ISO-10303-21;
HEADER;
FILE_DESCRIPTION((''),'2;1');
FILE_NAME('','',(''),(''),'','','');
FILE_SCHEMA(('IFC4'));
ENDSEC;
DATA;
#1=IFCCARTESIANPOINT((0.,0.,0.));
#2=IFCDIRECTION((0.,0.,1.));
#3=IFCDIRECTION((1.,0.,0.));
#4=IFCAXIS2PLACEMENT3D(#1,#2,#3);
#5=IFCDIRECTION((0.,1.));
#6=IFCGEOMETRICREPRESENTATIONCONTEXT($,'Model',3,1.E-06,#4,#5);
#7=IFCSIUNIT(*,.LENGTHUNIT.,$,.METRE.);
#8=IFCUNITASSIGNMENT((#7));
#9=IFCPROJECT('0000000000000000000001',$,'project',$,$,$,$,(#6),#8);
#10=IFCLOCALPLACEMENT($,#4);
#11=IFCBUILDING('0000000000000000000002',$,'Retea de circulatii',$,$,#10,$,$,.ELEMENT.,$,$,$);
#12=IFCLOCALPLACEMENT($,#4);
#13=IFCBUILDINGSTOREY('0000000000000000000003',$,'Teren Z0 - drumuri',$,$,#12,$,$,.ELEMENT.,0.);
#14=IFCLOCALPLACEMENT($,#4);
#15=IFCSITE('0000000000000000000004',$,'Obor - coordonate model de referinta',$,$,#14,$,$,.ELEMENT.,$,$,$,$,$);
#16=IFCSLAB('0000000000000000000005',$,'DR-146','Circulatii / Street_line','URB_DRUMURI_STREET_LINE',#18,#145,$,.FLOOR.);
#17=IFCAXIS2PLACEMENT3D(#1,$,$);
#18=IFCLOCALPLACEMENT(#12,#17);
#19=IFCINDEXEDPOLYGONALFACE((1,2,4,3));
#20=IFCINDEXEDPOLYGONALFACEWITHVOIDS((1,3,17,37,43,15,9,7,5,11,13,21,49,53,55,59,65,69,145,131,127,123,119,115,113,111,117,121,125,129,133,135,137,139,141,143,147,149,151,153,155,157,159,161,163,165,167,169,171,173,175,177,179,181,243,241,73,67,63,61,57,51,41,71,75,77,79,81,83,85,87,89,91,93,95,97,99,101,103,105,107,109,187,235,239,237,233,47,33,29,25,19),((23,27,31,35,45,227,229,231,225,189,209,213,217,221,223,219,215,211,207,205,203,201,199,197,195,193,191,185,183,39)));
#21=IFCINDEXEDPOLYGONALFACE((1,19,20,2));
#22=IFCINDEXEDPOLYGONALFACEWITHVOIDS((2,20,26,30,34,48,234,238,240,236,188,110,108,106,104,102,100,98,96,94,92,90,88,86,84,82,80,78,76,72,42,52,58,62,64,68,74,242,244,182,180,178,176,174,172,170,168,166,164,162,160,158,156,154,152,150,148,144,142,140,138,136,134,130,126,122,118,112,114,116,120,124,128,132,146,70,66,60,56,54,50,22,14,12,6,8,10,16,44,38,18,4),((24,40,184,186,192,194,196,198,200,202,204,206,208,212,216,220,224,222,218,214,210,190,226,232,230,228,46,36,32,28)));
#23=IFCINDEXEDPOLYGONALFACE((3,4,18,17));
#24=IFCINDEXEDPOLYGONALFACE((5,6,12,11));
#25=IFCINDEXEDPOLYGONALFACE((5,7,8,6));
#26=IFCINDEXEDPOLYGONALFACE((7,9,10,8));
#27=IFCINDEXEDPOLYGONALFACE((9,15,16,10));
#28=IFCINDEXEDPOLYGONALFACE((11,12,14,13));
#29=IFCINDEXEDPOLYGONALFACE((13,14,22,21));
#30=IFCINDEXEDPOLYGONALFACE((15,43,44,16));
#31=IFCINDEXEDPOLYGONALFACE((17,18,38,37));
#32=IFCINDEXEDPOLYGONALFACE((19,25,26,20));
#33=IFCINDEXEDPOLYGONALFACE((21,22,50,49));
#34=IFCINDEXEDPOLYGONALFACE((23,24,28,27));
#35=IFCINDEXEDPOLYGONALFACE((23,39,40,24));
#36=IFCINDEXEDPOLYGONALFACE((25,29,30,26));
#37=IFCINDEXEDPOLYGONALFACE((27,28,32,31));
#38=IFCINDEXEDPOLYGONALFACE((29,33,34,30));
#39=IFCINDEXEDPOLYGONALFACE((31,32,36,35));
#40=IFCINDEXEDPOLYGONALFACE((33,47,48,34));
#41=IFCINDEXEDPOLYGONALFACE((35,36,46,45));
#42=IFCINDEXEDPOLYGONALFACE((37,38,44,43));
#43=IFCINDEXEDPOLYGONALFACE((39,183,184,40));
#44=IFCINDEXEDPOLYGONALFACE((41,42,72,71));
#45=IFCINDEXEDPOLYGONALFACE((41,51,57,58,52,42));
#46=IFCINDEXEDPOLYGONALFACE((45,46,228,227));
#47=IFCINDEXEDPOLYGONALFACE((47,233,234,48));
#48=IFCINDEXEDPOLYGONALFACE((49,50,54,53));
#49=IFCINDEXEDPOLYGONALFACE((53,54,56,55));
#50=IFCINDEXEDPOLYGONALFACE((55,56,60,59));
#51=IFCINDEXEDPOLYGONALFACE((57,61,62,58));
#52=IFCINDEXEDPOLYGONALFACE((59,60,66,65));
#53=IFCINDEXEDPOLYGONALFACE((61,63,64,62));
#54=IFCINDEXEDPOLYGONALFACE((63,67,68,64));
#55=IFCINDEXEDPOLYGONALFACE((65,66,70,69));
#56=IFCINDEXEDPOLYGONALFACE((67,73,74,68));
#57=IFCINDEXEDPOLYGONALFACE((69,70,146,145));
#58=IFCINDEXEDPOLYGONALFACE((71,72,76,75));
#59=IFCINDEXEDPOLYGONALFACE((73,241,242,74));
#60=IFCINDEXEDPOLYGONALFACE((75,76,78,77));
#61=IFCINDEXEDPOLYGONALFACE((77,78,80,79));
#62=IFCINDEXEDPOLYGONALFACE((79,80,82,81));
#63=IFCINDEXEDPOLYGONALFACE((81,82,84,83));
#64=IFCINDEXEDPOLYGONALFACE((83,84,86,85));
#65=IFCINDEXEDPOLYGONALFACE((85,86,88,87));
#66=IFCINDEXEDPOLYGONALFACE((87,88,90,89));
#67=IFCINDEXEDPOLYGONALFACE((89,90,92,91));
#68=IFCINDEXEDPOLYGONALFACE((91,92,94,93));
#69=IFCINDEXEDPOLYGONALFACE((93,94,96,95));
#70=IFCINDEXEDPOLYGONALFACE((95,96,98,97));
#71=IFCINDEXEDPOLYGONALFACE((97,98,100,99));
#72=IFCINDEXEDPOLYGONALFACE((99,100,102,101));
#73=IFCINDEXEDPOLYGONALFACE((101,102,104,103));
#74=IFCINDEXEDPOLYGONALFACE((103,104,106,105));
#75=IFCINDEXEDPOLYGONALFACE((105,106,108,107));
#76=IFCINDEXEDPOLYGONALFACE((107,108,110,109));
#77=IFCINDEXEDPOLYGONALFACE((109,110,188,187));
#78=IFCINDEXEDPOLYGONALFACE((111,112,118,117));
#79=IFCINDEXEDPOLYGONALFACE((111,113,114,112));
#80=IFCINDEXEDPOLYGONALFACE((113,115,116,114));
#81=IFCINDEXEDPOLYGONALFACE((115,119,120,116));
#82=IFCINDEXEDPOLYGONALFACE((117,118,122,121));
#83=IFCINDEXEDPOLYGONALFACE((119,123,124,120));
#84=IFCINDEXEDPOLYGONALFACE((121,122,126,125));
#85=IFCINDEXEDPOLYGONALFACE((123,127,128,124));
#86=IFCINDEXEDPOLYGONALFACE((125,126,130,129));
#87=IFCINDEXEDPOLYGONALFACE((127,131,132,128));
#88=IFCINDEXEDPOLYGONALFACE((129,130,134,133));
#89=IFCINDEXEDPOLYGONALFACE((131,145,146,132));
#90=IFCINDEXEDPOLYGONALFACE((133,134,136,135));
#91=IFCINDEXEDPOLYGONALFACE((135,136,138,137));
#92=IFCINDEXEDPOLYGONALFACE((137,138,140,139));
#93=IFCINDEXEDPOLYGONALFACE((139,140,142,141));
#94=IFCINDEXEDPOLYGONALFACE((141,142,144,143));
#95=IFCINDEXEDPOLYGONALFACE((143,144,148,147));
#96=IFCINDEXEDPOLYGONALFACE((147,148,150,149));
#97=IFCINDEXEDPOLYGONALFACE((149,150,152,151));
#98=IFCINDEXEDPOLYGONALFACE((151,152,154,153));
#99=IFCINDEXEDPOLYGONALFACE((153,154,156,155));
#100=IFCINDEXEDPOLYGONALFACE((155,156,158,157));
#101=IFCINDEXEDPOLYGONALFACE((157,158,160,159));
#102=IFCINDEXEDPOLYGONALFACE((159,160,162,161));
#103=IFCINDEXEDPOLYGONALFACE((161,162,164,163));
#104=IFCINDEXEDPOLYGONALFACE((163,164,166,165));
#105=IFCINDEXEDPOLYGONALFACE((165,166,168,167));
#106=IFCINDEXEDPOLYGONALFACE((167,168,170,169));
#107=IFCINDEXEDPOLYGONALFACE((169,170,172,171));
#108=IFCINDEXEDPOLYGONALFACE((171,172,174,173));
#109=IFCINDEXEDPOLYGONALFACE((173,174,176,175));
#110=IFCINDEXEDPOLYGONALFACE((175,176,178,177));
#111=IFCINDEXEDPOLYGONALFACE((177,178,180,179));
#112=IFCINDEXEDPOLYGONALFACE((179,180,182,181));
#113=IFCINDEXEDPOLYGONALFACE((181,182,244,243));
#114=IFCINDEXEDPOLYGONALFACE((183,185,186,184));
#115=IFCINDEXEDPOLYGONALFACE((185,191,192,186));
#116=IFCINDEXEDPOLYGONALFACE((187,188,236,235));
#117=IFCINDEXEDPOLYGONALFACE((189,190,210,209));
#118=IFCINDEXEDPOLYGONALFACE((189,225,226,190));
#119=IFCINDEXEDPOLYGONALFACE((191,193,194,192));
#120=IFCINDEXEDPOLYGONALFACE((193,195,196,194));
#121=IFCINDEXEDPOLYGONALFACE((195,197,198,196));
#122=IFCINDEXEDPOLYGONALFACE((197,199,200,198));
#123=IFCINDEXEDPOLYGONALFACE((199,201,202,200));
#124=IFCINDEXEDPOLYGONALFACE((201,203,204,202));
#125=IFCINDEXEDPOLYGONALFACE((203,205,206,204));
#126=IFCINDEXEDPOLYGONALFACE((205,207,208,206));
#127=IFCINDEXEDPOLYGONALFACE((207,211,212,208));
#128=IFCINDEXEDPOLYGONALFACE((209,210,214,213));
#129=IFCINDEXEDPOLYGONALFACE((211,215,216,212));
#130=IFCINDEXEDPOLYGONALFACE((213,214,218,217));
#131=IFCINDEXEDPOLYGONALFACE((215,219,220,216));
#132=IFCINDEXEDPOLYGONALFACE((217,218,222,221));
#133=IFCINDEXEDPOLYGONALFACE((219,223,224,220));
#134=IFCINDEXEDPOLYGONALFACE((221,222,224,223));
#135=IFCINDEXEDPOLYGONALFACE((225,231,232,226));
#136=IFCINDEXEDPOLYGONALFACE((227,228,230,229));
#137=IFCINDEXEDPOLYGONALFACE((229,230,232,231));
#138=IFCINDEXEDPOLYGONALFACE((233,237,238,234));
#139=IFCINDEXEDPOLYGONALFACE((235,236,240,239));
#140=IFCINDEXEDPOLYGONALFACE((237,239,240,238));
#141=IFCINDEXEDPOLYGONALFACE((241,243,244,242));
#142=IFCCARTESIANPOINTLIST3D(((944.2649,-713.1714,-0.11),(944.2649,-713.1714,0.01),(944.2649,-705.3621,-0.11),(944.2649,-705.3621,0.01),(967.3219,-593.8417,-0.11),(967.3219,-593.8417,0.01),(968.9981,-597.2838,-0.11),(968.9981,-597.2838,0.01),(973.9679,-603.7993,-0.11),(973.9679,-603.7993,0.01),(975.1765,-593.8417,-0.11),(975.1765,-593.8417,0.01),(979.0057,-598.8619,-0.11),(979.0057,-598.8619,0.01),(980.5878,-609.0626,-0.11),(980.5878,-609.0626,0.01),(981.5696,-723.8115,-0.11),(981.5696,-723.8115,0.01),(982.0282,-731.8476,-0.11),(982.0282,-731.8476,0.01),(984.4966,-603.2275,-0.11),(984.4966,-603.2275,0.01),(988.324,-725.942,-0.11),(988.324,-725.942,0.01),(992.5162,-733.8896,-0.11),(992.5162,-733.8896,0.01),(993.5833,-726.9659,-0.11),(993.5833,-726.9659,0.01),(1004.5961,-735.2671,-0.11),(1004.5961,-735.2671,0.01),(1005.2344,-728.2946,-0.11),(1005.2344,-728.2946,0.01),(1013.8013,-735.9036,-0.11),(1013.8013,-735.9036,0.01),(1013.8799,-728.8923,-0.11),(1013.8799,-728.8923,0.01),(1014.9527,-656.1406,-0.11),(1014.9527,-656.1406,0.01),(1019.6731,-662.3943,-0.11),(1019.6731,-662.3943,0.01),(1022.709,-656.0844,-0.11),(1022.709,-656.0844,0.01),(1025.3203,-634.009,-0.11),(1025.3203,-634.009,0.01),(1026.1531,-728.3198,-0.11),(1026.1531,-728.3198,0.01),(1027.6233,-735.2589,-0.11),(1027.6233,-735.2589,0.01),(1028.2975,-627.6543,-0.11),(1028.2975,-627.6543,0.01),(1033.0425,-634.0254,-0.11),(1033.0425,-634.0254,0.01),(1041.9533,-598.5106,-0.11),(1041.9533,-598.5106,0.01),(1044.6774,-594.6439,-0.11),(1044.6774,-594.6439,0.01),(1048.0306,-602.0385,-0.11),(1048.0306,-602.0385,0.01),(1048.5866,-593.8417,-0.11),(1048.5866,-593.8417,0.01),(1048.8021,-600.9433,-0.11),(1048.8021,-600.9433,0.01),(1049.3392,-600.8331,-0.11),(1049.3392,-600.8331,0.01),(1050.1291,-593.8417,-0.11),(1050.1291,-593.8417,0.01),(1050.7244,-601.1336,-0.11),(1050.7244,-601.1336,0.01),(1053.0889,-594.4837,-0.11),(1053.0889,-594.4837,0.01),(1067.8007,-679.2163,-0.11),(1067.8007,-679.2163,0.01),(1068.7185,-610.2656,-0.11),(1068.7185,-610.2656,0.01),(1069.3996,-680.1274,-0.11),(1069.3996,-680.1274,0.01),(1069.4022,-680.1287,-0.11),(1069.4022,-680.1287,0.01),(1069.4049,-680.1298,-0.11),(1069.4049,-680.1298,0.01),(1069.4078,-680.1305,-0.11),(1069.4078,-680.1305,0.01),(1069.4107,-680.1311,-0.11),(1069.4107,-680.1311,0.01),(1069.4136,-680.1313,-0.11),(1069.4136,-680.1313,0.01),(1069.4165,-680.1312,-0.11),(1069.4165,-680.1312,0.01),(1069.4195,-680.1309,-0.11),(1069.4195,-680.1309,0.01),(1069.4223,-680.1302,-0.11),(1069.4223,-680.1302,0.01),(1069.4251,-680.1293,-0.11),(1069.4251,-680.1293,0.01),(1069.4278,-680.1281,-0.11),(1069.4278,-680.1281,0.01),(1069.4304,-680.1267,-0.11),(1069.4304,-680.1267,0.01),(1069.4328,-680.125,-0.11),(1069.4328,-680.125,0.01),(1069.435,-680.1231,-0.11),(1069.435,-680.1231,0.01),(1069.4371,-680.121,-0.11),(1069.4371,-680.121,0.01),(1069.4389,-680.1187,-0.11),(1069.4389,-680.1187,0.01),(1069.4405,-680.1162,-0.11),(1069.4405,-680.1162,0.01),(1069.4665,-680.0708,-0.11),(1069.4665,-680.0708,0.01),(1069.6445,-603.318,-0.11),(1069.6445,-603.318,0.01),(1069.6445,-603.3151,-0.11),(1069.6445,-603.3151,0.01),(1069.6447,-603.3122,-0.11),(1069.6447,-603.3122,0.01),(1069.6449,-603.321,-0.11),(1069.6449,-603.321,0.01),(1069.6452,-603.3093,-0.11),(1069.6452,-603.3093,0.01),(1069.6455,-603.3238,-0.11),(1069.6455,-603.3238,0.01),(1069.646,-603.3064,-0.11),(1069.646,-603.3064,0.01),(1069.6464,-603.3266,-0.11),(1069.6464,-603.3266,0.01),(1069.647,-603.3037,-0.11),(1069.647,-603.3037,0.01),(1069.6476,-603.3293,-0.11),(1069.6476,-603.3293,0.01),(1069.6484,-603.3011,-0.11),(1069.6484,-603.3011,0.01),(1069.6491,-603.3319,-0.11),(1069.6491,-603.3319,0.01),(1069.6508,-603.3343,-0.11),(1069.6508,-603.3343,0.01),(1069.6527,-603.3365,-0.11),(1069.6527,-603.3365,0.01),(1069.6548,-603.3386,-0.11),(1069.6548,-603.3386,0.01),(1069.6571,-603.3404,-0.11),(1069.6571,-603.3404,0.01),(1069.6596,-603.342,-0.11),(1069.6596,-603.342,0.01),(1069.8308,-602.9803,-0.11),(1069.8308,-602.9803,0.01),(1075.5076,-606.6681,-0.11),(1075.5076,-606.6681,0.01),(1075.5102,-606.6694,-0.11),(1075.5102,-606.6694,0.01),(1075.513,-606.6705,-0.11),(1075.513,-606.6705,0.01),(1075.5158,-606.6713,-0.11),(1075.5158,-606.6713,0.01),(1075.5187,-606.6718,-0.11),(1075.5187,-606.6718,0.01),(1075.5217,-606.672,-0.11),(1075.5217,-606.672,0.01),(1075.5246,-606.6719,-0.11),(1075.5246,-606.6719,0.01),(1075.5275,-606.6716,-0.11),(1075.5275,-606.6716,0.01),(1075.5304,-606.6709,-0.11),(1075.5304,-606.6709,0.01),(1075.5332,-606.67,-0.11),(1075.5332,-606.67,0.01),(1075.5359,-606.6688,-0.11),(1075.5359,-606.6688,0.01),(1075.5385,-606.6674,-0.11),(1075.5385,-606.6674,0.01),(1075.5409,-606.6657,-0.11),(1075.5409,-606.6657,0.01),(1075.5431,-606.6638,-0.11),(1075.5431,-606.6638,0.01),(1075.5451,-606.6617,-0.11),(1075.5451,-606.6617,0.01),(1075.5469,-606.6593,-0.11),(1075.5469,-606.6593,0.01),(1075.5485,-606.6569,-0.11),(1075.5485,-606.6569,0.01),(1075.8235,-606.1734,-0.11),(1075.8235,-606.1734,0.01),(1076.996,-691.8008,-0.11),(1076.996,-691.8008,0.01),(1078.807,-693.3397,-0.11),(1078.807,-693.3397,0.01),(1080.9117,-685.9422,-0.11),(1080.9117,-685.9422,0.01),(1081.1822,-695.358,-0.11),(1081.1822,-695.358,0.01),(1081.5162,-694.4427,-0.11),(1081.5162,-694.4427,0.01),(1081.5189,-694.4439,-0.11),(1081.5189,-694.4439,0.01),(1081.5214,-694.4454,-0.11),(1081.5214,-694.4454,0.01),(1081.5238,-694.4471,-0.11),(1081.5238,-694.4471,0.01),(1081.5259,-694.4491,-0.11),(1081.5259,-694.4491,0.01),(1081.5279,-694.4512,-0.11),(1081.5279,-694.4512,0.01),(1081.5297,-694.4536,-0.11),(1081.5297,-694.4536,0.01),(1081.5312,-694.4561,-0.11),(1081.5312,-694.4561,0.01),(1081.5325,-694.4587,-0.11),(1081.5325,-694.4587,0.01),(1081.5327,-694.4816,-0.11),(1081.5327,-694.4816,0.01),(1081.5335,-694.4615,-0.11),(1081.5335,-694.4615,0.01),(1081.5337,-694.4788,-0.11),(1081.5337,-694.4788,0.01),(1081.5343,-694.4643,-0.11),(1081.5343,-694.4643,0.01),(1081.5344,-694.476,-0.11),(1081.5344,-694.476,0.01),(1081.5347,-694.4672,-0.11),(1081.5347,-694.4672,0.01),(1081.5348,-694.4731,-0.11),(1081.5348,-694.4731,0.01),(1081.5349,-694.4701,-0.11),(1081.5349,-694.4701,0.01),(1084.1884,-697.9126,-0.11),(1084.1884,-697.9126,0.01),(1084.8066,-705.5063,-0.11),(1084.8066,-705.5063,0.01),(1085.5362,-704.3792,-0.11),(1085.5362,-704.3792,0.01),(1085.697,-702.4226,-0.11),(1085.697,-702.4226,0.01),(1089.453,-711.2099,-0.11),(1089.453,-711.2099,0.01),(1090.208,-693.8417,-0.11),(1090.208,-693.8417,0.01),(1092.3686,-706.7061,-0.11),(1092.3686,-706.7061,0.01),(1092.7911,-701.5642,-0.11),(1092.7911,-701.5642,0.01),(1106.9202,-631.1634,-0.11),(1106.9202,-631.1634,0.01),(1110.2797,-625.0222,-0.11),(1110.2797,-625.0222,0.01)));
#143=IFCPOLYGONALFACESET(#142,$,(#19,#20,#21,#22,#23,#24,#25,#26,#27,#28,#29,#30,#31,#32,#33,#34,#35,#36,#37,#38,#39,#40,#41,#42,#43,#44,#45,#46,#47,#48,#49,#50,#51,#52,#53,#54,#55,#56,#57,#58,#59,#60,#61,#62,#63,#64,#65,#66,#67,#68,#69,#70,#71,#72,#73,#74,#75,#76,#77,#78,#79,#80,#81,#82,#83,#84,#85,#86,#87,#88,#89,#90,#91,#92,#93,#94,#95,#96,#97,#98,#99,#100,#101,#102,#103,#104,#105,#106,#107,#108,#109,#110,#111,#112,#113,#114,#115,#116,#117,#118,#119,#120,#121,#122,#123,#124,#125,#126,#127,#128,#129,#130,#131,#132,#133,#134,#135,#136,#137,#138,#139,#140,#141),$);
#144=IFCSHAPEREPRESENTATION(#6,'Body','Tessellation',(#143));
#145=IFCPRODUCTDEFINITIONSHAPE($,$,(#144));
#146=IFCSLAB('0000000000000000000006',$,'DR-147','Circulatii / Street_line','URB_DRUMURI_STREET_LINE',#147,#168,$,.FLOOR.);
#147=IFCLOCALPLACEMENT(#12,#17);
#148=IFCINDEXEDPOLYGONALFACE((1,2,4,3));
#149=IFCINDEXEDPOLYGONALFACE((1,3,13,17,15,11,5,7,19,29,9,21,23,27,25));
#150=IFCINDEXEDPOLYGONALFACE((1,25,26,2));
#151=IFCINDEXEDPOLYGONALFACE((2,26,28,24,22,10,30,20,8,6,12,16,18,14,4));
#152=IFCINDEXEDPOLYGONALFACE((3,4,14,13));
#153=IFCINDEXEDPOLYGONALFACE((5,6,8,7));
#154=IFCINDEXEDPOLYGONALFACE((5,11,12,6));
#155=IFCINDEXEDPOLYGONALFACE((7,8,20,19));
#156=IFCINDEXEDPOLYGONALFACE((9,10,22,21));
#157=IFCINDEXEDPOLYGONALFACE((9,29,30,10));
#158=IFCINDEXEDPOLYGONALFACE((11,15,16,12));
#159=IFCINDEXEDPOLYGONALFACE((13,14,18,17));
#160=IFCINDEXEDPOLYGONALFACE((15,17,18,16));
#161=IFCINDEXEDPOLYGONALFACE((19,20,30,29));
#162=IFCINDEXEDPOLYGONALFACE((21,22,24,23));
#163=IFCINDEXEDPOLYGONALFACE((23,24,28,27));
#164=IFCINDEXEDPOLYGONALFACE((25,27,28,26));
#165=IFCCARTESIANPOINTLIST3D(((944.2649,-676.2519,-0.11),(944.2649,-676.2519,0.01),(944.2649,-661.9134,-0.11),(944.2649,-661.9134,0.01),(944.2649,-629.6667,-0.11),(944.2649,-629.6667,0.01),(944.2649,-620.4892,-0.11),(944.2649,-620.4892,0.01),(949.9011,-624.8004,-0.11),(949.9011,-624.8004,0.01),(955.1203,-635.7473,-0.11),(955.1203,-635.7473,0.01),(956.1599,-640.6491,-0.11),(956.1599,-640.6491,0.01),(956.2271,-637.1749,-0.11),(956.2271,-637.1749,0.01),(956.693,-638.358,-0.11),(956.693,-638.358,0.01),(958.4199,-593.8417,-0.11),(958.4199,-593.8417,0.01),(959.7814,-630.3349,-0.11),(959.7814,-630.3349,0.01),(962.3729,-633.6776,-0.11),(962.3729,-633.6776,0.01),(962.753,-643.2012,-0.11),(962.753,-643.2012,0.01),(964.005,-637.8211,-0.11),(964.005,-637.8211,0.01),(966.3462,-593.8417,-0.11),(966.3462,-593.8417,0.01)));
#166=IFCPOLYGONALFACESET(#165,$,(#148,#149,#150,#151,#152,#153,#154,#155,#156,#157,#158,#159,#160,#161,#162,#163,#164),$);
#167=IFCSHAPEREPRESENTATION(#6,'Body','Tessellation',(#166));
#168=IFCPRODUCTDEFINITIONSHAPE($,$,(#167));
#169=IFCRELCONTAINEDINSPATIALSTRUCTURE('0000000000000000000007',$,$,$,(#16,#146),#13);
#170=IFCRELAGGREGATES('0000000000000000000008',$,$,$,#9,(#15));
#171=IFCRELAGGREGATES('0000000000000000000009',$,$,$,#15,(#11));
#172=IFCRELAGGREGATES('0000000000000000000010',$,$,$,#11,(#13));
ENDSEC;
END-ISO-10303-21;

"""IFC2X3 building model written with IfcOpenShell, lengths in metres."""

from ifc_helpers import new_model, si_unit, direction, frame, origin_with_axes, place, context, project, spatial, polyline, outline, extrude, element, save


model = new_model("IFC2X3")

# Units and contexts
model_context = context("Model", 3, precision=1e-06, world=origin_with_axes(), true_north=direction((0.0, 1.0)))
ifc_project = project(units=[si_unit("LENGTHUNIT", "METRE")], contexts=[model_context])

# Site, building, storey
site_placement = place(None, origin_with_axes())
site = spatial("IfcSite", under=ifc_project, at=site_placement, Name="Obor - coordonate model de referinta", CompositionType="ELEMENT")
building_placement = place(None, origin_with_axes())
building = spatial("IfcBuilding", under=site, at=building_placement, Name="Retea de circulatii", CompositionType="ELEMENT")
storey_placement = place(None, origin_with_axes())
storey = spatial("IfcBuildingStorey", under=building, at=storey_placement, Name="Teren Z0 - drumuri", CompositionType="ELEMENT", Elevation=0.0)

# Slabs
slab_1_placement = place(None, origin_with_axes())
element("IfcSlab", 1, at=slab_1_placement, inside=storey, Name="DR-146", Description="Circulatii / Street_line", ObjectType="URB_DRUMURI_STREET_LINE", PredefinedType="FLOOR", context=model_context, shape_type="SweptSolid", body=[
    extrude(outline(polyline([(1041.9533, -598.5106), (1028.2975, -627.6543), (984.4966, -603.2275), (979.0057, -598.8619), (975.1765, -593.8417), (967.3219, -593.8417), (968.9981, -597.2838), (973.9679, -603.7993), (980.5878, -609.0626), (1025.3203, -634.009), (1014.9527, -656.1406), (981.5696, -723.8115), (944.2649, -705.3621), (944.2649, -713.1714), (982.0282, -731.8476), (992.5162, -733.8896), (1004.5961, -735.2671), (1013.8013, -735.9036), (1027.6233, -735.2589), (1089.453, -711.2099), (1092.3686, -706.7061), (1092.7911, -701.5642), (1090.208, -693.8417), (1080.9117, -685.9422), (1069.4665, -680.0708), (1069.4405, -680.1162), (1069.4389, -680.1187), (1069.4371, -680.121), (1069.435, -680.1231), (1069.4328, -680.125), (1069.4304, -680.1267), (1069.4278, -680.1281), (1069.4251, -680.1293), (1069.4223, -680.1302), (1069.4195, -680.1309), (1069.4165, -680.1312), (1069.4136, -680.1313), (1069.4107, -680.1311), (1069.4078, -680.1305), (1069.4049, -680.1298), (1069.4022, -680.1287), (1069.3996, -680.1274), (1067.8007, -679.2163), (1022.709, -656.0844), (1033.0425, -634.0254), (1048.0306, -602.0385), (1048.8021, -600.9433), (1049.3392, -600.8331), (1050.7244, -601.1336), (1068.7185, -610.2656), (1106.9202, -631.1634), (1110.2797, -625.0222), (1075.8235, -606.1734), (1075.5485, -606.6569), (1075.5469, -606.6593), (1075.5451, -606.6617), (1075.5431, -606.6638), (1075.5409, -606.6657), (1075.5385, -606.6674), (1075.5359, -606.6688), (1075.5332, -606.67), (1075.5304, -606.6709), (1075.5275, -606.6716), (1075.5246, -606.6719), (1075.5217, -606.672), (1075.5187, -606.6718), (1075.5158, -606.6713), (1075.513, -606.6705), (1075.5102, -606.6694), (1075.5076, -606.6681), (1069.6596, -603.342), (1069.6571, -603.3404), (1069.6548, -603.3386), (1069.6527, -603.3365), (1069.6508, -603.3343), (1069.6491, -603.3319), (1069.6476, -603.3293), (1069.6464, -603.3266), (1069.6455, -603.3238), (1069.6449, -603.321), (1069.6445, -603.318), (1069.6445, -603.3151), (1069.6447, -603.3122), (1069.6452, -603.3093), (1069.646, -603.3064), (1069.647, -603.3037), (1069.6484, -603.3011), (1069.8308, -602.9803), (1053.0889, -594.4837), (1050.1291, -593.8417), (1048.5866, -593.8417), (1044.6774, -594.6439), (1041.9533, -598.5106)]), holes=[polyline([(1013.8799, -728.8923), (1005.2344, -728.2946), (993.5833, -726.9659), (988.324, -725.942), (1019.6731, -662.3943), (1076.996, -691.8008), (1078.807, -693.3397), (1081.5162, -694.4427), (1081.5189, -694.4439), (1081.5214, -694.4454), (1081.5238, -694.4471), (1081.5259, -694.4491), (1081.5279, -694.4512), (1081.5297, -694.4536), (1081.5312, -694.4561), (1081.5325, -694.4587), (1081.5335, -694.4615), (1081.5343, -694.4643), (1081.5347, -694.4672), (1081.5349, -694.4701), (1081.5348, -694.4731), (1081.5344, -694.476), (1081.5337, -694.4788), (1081.5327, -694.4816), (1081.1822, -695.358), (1084.1884, -697.9126), (1085.697, -702.4226), (1085.5362, -704.3792), (1084.8066, -705.5063), (1026.1531, -728.3198), (1013.8799, -728.8923)])]), frame((0.0, 0.0, -0.11), z_axis=(0.0, 0.0, 1.0), x_axis=(1.0, 0.0, 0.0)), (0.0, 0.0, 1.0), 0.12),
])
slab_2_placement = place(None, origin_with_axes())
element("IfcSlab", 2, at=slab_2_placement, inside=storey, Name="DR-147", Description="Circulatii / Street_line", ObjectType="URB_DRUMURI_STREET_LINE", PredefinedType="FLOOR", context=model_context, shape_type="SweptSolid", body=[
    extrude(outline(polyline([(959.7814, -630.3349), (949.9011, -624.8004), (966.3462, -593.8417), (958.4199, -593.8417), (944.2649, -620.4892), (944.2649, -629.6667), (955.1203, -635.7473), (956.2271, -637.1749), (956.693, -638.358), (956.1599, -640.6491), (944.2649, -661.9134), (944.2649, -676.2519), (962.753, -643.2012), (964.005, -637.8211), (962.3729, -633.6776), (959.7814, -630.3349)])), frame((0.0, 0.0, -0.11), z_axis=(0.0, 0.0, 1.0), x_axis=(1.0, 0.0, 0.0)), (0.0, 0.0, 1.0), 0.12),
])

save(model, "model.ifc")
